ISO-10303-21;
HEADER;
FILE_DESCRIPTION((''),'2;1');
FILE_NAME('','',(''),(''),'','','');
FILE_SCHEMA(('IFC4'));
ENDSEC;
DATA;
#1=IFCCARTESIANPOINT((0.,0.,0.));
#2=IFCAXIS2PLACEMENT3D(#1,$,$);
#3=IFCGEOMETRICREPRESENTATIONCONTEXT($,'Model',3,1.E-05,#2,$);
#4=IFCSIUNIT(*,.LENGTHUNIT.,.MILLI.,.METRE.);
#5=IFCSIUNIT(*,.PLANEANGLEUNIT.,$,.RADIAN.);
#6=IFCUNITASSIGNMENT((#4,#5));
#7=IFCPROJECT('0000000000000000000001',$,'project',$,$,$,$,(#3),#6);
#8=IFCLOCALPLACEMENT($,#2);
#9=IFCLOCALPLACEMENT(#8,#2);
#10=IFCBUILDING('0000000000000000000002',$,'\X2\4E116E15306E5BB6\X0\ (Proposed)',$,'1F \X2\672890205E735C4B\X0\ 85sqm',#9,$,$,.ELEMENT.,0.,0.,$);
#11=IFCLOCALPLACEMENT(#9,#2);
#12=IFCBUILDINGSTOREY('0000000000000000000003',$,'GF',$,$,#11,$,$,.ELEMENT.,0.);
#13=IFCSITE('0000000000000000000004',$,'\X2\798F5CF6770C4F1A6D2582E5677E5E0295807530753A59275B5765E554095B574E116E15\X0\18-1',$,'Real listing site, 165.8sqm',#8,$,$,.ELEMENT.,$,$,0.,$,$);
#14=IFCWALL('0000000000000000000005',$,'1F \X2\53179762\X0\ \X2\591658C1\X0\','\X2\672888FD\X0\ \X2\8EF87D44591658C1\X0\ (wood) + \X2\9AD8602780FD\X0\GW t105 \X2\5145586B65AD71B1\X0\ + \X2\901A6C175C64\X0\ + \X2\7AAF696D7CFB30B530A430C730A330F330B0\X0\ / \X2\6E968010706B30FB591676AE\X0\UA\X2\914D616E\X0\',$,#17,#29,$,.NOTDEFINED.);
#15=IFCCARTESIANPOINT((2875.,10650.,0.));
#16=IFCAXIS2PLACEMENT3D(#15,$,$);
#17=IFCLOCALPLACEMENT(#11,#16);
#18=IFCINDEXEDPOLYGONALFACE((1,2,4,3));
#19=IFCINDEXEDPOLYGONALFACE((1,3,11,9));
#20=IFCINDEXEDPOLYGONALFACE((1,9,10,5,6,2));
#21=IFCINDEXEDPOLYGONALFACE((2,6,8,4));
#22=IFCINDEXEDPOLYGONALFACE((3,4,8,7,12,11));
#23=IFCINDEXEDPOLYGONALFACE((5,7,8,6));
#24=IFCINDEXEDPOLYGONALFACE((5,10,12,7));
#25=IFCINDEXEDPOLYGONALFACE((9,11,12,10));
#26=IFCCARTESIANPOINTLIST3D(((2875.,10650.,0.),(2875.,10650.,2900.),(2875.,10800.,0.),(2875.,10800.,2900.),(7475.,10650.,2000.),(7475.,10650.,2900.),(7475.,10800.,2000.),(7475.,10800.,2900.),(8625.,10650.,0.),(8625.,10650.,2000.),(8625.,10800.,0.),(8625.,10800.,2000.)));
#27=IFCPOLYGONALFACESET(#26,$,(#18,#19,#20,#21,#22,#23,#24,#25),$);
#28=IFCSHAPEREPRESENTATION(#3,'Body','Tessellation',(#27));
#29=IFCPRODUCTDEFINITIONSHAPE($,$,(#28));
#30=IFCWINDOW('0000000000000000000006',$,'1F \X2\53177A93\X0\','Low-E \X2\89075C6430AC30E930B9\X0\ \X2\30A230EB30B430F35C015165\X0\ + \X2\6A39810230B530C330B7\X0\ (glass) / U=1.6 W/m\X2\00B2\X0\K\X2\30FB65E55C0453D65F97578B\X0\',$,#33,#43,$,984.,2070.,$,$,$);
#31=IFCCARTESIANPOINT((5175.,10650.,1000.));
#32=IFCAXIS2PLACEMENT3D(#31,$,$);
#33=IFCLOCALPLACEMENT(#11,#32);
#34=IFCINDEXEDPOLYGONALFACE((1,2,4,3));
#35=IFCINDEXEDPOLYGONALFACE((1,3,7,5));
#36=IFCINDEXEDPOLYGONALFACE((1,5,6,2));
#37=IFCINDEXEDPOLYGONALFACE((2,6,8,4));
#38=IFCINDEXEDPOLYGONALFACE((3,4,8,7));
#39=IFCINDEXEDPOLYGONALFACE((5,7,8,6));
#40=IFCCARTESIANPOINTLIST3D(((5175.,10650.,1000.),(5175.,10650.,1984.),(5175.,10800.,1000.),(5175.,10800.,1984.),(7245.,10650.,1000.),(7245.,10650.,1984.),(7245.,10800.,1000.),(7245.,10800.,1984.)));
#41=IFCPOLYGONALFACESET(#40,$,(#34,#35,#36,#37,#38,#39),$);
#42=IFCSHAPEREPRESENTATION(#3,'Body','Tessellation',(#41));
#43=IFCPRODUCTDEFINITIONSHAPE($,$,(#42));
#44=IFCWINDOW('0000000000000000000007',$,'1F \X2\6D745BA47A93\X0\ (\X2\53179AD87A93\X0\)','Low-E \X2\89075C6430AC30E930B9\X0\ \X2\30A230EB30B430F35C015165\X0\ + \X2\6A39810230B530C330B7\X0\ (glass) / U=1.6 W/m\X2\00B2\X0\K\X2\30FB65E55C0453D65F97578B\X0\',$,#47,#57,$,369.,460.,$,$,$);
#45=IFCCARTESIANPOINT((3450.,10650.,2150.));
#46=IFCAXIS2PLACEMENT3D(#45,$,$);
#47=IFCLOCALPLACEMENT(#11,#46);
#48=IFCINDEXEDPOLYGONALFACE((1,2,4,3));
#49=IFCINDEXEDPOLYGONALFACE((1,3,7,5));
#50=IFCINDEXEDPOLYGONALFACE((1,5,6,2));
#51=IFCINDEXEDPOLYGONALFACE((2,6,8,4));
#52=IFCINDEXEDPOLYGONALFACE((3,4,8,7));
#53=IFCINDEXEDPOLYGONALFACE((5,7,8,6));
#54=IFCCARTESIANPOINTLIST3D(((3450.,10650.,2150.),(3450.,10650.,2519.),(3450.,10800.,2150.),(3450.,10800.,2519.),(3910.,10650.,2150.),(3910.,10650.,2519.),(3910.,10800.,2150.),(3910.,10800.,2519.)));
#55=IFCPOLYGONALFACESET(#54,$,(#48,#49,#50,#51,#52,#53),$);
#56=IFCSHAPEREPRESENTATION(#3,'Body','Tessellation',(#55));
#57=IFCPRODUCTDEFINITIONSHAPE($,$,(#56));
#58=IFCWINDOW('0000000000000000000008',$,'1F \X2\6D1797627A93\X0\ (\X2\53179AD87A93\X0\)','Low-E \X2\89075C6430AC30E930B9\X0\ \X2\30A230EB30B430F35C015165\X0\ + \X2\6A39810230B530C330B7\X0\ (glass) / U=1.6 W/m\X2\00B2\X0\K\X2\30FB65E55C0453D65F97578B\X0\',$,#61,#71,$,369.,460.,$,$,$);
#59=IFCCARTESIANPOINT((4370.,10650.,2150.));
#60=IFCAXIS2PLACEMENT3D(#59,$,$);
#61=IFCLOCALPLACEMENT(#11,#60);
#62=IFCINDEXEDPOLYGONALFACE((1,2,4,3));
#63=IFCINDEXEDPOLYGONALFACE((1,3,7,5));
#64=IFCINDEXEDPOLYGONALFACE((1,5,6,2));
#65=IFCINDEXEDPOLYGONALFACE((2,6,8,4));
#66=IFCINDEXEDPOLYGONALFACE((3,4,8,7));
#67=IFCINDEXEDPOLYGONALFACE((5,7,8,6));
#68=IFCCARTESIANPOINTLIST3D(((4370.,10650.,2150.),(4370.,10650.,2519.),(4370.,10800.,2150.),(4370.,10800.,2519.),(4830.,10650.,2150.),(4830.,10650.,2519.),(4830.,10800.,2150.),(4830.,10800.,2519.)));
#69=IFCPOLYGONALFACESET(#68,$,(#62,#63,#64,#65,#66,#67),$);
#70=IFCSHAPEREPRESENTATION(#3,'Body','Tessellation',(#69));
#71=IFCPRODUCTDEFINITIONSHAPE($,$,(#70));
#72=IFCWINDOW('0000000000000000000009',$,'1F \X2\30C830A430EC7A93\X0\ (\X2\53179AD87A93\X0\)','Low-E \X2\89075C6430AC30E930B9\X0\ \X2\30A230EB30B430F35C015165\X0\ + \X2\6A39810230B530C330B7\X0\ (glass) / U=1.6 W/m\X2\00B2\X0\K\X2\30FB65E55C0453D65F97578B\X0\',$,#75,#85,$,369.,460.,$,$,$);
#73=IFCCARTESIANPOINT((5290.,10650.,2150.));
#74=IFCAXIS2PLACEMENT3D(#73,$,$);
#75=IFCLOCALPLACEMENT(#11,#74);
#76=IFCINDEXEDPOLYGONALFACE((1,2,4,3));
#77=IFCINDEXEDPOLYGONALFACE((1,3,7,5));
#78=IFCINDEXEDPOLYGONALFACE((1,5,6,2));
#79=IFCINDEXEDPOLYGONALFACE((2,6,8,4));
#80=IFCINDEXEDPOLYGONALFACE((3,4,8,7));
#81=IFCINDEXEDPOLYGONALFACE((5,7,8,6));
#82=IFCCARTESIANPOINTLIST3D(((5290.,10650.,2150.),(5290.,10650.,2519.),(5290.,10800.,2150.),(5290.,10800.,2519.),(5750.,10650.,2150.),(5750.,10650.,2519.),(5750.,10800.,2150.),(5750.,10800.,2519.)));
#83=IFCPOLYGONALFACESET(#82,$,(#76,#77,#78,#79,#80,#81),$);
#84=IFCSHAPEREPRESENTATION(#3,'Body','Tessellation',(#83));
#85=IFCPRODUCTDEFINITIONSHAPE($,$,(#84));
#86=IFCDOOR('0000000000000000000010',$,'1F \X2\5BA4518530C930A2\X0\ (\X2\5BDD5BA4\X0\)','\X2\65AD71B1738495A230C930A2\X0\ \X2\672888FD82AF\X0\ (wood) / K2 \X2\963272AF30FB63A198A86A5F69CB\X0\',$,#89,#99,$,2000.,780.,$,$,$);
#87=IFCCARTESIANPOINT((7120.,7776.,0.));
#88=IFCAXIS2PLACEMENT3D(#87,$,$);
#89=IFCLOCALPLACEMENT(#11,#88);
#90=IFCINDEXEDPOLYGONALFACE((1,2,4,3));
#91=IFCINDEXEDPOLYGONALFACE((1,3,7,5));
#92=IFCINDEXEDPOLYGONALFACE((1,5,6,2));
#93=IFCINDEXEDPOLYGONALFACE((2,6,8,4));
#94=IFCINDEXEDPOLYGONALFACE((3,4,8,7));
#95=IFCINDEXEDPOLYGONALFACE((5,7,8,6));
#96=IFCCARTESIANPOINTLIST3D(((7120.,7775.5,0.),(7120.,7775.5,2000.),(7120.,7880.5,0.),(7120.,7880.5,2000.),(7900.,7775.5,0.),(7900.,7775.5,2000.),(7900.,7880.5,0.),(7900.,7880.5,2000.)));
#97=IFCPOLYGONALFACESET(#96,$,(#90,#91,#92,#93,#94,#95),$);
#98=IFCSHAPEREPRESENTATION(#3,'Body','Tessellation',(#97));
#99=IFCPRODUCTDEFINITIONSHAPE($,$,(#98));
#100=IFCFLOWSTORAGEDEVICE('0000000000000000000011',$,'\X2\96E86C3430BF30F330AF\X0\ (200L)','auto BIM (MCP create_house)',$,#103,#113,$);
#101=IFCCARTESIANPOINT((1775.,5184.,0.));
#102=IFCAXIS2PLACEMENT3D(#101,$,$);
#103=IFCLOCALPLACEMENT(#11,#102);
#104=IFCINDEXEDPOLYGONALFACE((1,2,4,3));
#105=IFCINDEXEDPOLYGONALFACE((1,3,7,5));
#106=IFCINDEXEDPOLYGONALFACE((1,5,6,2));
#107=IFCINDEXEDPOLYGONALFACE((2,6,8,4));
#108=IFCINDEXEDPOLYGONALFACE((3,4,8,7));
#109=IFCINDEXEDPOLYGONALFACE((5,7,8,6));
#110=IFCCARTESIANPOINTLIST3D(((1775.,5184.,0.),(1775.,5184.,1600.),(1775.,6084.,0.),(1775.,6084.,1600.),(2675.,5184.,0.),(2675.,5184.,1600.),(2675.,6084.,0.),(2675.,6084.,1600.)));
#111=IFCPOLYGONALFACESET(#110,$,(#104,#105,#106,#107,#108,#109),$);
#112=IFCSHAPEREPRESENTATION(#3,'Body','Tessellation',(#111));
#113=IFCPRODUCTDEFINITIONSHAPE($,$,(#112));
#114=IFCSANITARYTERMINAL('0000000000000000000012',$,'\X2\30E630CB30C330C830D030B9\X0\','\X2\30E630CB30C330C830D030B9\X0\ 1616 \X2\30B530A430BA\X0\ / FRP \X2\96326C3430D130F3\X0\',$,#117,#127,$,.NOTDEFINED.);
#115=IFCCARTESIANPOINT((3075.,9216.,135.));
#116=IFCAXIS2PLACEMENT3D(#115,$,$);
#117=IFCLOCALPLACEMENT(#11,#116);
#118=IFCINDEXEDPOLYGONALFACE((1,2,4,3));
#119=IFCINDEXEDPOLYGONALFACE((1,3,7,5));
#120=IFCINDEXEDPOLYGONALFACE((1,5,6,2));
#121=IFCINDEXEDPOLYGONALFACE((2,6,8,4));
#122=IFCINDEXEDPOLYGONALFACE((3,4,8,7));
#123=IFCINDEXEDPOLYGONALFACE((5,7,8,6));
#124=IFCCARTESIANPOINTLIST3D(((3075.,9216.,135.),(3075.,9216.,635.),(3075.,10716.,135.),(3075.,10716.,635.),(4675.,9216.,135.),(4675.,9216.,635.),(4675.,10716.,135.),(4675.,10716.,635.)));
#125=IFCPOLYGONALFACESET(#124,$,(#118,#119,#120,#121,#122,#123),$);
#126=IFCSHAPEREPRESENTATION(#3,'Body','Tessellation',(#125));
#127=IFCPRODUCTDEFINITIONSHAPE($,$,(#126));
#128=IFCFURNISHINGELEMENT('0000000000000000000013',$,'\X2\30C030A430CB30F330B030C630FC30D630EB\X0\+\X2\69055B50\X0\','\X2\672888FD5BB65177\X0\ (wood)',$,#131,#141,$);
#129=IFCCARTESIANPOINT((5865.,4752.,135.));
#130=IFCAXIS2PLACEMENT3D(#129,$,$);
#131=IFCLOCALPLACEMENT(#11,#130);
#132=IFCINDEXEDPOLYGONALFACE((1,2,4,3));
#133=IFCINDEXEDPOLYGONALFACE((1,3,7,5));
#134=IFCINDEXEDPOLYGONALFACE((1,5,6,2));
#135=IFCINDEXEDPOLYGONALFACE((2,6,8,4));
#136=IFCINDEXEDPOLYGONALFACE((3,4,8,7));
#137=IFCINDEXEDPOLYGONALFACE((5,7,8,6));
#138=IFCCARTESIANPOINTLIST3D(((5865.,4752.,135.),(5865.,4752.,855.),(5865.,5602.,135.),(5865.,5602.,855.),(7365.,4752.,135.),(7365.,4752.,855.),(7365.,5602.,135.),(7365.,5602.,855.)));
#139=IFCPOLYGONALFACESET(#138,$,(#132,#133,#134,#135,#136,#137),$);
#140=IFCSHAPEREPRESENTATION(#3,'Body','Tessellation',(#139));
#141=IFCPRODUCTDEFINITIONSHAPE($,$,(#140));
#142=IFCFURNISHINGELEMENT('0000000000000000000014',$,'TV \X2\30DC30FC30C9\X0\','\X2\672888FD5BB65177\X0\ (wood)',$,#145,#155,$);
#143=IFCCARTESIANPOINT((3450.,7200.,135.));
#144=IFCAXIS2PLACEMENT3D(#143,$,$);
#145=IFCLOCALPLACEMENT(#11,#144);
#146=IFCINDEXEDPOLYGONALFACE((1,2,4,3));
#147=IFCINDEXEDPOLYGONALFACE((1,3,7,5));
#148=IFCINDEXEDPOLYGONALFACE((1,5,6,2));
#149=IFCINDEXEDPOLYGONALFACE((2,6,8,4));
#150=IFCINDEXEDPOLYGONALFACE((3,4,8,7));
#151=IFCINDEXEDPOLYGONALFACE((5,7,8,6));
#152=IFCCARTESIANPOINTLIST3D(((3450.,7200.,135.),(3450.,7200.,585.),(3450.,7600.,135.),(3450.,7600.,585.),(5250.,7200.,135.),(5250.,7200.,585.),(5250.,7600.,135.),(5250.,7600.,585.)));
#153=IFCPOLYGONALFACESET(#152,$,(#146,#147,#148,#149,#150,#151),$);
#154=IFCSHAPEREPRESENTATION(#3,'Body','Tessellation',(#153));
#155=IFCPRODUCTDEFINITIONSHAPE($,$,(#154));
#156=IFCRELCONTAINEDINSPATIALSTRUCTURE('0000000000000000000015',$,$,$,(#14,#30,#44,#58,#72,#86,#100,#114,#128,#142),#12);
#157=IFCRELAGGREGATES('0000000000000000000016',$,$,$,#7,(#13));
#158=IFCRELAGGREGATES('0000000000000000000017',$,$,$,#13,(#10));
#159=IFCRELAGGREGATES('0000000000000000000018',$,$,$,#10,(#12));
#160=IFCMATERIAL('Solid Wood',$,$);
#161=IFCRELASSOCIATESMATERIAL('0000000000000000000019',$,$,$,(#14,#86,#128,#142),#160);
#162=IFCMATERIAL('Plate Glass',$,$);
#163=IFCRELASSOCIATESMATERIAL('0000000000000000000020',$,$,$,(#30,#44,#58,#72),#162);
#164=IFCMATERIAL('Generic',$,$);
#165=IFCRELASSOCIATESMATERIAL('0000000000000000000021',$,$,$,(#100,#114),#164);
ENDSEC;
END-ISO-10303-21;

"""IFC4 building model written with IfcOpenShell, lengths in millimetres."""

from ifc_helpers import new_model, si_unit, frame, frame_2d, origin, place, context, project, spatial, rectangle, extrude, material, element, fill, save


model = new_model("IFC4")

# Units and contexts
model_context = context("Model", 3, precision=1e-05, world=origin())
ifc_project = project(units=[si_unit("LENGTHUNIT", "METRE", prefix="MILLI"), si_unit("PLANEANGLEUNIT", "RADIAN")], contexts=[model_context])

# Site, building, storey
site_placement = place(None, origin())
site = spatial("IfcSite", under=ifc_project, at=site_placement, Name="福島県会津若松市門田町大字日吉字丑渕18-1", ObjectType="Real listing site, 165.8sqm", CompositionType="ELEMENT", RefElevation=0.0)
building_placement = place(site_placement, origin())
building = spatial("IfcBuilding", under=site, at=building_placement, Name="丑渕の家 (Proposed)", ObjectType="1F 木造平屋 85sqm", CompositionType="ELEMENT", ElevationOfRefHeight=0.0, ElevationOfTerrain=0.0)
storey_placement = place(building_placement, origin())
storey = spatial("IfcBuildingStorey", under=building, at=storey_placement, Name="GF", CompositionType="ELEMENT", Elevation=0.0)

# Wall, openings, windows
ifc_material_1 = material(Name="Solid Wood")
wall_1_placement = place(storey_placement, frame((2875.0, 10650.0, 0.0)))
wall_1 = element("IfcWall", 1, at=wall_1_placement, inside=storey, material=ifc_material_1, Name="1F 北面 外壁", Description="木製 軸組外壁 (wood) + 高性能GW t105 充填断熱 + 通気層 + 窯業系サイディング / 準耐火・外皮UA配慮", PredefinedType="NOTDEFINED", context=model_context, shape_type="SweptSolid", body=[
    extrude(rectangle(XDim=5750.0, YDim=150.0, at=frame_2d((2875.0, 75.0))), frame((2875.0, 10650.0, 0.0)), (0.0, 0.0, 1.0), 2900.0),
])
opening_1_placement = place(storey_placement, frame((5175.0, 10650.0, 1000.0)))
opening_1 = element("IfcOpeningElement", 2, at=opening_1_placement, cuts=wall_1, PredefinedType="NOTDEFINED", context=model_context, shape_type="SweptSolid", body=[
    extrude(rectangle(XDim=2070.0, YDim=150.0, at=frame_2d((1035.0, 75.0))), frame((5175.0, 10650.0, 1000.0)), (0.0, 0.0, 1.0), 984.0),
])
opening_2_placement = place(storey_placement, frame((3450.0, 10650.0, 2150.0)))
opening_2 = element("IfcOpeningElement", 3, at=opening_2_placement, cuts=wall_1, PredefinedType="NOTDEFINED", context=model_context, shape_type="SweptSolid", body=[
    extrude(rectangle(XDim=460.0, YDim=150.0, at=frame_2d((230.0, 75.0))), frame((3450.0, 10650.0, 2150.0)), (0.0, 0.0, 1.0), 369.0),
])
opening_3_placement = place(storey_placement, frame((4370.0, 10650.0, 2150.0)))
opening_3 = element("IfcOpeningElement", 4, at=opening_3_placement, cuts=wall_1, PredefinedType="NOTDEFINED", context=model_context, shape_type="SweptSolid", body=[
    extrude(rectangle(XDim=460.0, YDim=150.0, at=frame_2d((230.0, 75.0))), frame((4370.0, 10650.0, 2150.0)), (0.0, 0.0, 1.0), 369.0),
])
opening_4_placement = place(storey_placement, frame((5290.0, 10650.0, 2150.0)))
opening_4 = element("IfcOpeningElement", 5, at=opening_4_placement, cuts=wall_1, PredefinedType="NOTDEFINED", context=model_context, shape_type="SweptSolid", body=[
    extrude(rectangle(XDim=460.0, YDim=150.0, at=frame_2d((230.0, 75.0))), frame((5290.0, 10650.0, 2150.0)), (0.0, 0.0, 1.0), 369.0),
])
ifc_material_2 = material(Name="Plate Glass")
window_1_placement = place(storey_placement, frame((5175.0, 10650.0, 1000.0)))
window_1 = element("IfcWindow", 6, at=window_1_placement, inside=storey, material=ifc_material_2, Name="1F 北窓", Description="Low-E 複層ガラス アルゴン封入 + 樹脂サッシ (glass) / U=1.6 W/m²K・日射取得型", OverallHeight=984.0, OverallWidth=2070.0, context=model_context, shape_type="SweptSolid", body=[
    extrude(rectangle(XDim=2070.0, YDim=150.0, at=frame_2d((1035.0, 75.0))), frame((5175.0, 10650.0, 1000.0)), (0.0, 0.0, 1.0), 984.0),
])
fill(opening_1, window_1)
window_2_placement = place(storey_placement, frame((3450.0, 10650.0, 2150.0)))
window_2 = element("IfcWindow", 7, at=window_2_placement, inside=storey, material=ifc_material_2, Name="1F 浴室窓 (北高窓)", Description="Low-E 複層ガラス アルゴン封入 + 樹脂サッシ (glass) / U=1.6 W/m²K・日射取得型", OverallHeight=369.0, OverallWidth=460.0, context=model_context, shape_type="SweptSolid", body=[
    extrude(rectangle(XDim=460.0, YDim=150.0, at=frame_2d((230.0, 75.0))), frame((3450.0, 10650.0, 2150.0)), (0.0, 0.0, 1.0), 369.0),
])
fill(opening_2, window_2)
window_3_placement = place(storey_placement, frame((4370.0, 10650.0, 2150.0)))
window_3 = element("IfcWindow", 8, at=window_3_placement, inside=storey, material=ifc_material_2, Name="1F 洗面窓 (北高窓)", Description="Low-E 複層ガラス アルゴン封入 + 樹脂サッシ (glass) / U=1.6 W/m²K・日射取得型", OverallHeight=369.0, OverallWidth=460.0, context=model_context, shape_type="SweptSolid", body=[
    extrude(rectangle(XDim=460.0, YDim=150.0, at=frame_2d((230.0, 75.0))), frame((4370.0, 10650.0, 2150.0)), (0.0, 0.0, 1.0), 369.0),
])
fill(opening_3, window_3)
window_4_placement = place(storey_placement, frame((5290.0, 10650.0, 2150.0)))
window_4 = element("IfcWindow", 9, at=window_4_placement, inside=storey, material=ifc_material_2, Name="1F トイレ窓 (北高窓)", Description="Low-E 複層ガラス アルゴン封入 + 樹脂サッシ (glass) / U=1.6 W/m²K・日射取得型", OverallHeight=369.0, OverallWidth=460.0, context=model_context, shape_type="SweptSolid", body=[
    extrude(rectangle(XDim=460.0, YDim=150.0, at=frame_2d((230.0, 75.0))), frame((5290.0, 10650.0, 2150.0)), (0.0, 0.0, 1.0), 369.0),
])
fill(opening_4, window_4)

# Door
door_1_placement = place(storey_placement, frame((7120.0, 7776.0, 0.0)))
element("IfcDoor", 10, at=door_1_placement, inside=storey, material=ifc_material_1, Name="1F 室内ドア (寝室)", Description="断熱玄関ドア 木製芯 (wood) / K2 防犯・採風機構", OverallHeight=2000.0, OverallWidth=780.0, context=model_context, shape_type="SweptSolid", body=[
    extrude(rectangle(XDim=780.0, YDim=105.0, at=frame_2d((390.0, 52.0))), frame((7120.0, 7776.0, 0.0)), (0.0, 0.0, 1.0), 2000.0),
])

# Flow storage device
ifc_material_3 = material(Name="Generic")
flow_storage_device_placement = place(storey_placement, frame((1775.0, 5184.0, 0.0)))
element("IfcFlowStorageDevice", 11, at=flow_storage_device_placement, inside=storey, material=ifc_material_3, Name="雨水タンク (200L)", Description="auto BIM (MCP create_house)", context=model_context, shape_type="SweptSolid", body=[
    extrude(rectangle(XDim=900.0, YDim=900.0, at=frame_2d((450.0, 450.0))), frame((1775.0, 5184.0, 0.0)), (0.0, 0.0, 1.0), 1600.0),
])

# Sanitary terminal
sanitary_terminal_placement = place(storey_placement, frame((3075.0, 9216.0, 135.0)))
element("IfcSanitaryTerminal", 12, at=sanitary_terminal_placement, inside=storey, material=ifc_material_3, Name="ユニットバス", Description="ユニットバス 1616 サイズ / FRP 防水パン", PredefinedType="NOTDEFINED", context=model_context, shape_type="SweptSolid", body=[
    extrude(rectangle(XDim=1600.0, YDim=1500.0, at=frame_2d((800.0, 750.0))), frame((3075.0, 9216.0, 135.0)), (0.0, 0.0, 1.0), 500.0),
])

# Furnishing elements
furnishing_1_placement = place(storey_placement, frame((5865.0, 4752.0, 135.0)))
element("IfcFurnishingElement", 13, at=furnishing_1_placement, inside=storey, material=ifc_material_1, Name="ダイニングテーブル+椅子", Description="木製家具 (wood)", context=model_context, shape_type="SweptSolid", body=[
    extrude(rectangle(XDim=1500.0, YDim=850.0, at=frame_2d((750.0, 425.0))), frame((5865.0, 4752.0, 135.0)), (0.0, 0.0, 1.0), 720.0),
])
furnishing_2_placement = place(storey_placement, frame((3450.0, 7200.0, 135.0)))
element("IfcFurnishingElement", 14, at=furnishing_2_placement, inside=storey, material=ifc_material_1, Name="TV ボード", Description="木製家具 (wood)", context=model_context, shape_type="SweptSolid", body=[
    extrude(rectangle(XDim=1800.0, YDim=400.0, at=frame_2d((900.0, 200.0))), frame((3450.0, 7200.0, 135.0)), (0.0, 0.0, 1.0), 450.0),
])

save(model, "model.ifc")
